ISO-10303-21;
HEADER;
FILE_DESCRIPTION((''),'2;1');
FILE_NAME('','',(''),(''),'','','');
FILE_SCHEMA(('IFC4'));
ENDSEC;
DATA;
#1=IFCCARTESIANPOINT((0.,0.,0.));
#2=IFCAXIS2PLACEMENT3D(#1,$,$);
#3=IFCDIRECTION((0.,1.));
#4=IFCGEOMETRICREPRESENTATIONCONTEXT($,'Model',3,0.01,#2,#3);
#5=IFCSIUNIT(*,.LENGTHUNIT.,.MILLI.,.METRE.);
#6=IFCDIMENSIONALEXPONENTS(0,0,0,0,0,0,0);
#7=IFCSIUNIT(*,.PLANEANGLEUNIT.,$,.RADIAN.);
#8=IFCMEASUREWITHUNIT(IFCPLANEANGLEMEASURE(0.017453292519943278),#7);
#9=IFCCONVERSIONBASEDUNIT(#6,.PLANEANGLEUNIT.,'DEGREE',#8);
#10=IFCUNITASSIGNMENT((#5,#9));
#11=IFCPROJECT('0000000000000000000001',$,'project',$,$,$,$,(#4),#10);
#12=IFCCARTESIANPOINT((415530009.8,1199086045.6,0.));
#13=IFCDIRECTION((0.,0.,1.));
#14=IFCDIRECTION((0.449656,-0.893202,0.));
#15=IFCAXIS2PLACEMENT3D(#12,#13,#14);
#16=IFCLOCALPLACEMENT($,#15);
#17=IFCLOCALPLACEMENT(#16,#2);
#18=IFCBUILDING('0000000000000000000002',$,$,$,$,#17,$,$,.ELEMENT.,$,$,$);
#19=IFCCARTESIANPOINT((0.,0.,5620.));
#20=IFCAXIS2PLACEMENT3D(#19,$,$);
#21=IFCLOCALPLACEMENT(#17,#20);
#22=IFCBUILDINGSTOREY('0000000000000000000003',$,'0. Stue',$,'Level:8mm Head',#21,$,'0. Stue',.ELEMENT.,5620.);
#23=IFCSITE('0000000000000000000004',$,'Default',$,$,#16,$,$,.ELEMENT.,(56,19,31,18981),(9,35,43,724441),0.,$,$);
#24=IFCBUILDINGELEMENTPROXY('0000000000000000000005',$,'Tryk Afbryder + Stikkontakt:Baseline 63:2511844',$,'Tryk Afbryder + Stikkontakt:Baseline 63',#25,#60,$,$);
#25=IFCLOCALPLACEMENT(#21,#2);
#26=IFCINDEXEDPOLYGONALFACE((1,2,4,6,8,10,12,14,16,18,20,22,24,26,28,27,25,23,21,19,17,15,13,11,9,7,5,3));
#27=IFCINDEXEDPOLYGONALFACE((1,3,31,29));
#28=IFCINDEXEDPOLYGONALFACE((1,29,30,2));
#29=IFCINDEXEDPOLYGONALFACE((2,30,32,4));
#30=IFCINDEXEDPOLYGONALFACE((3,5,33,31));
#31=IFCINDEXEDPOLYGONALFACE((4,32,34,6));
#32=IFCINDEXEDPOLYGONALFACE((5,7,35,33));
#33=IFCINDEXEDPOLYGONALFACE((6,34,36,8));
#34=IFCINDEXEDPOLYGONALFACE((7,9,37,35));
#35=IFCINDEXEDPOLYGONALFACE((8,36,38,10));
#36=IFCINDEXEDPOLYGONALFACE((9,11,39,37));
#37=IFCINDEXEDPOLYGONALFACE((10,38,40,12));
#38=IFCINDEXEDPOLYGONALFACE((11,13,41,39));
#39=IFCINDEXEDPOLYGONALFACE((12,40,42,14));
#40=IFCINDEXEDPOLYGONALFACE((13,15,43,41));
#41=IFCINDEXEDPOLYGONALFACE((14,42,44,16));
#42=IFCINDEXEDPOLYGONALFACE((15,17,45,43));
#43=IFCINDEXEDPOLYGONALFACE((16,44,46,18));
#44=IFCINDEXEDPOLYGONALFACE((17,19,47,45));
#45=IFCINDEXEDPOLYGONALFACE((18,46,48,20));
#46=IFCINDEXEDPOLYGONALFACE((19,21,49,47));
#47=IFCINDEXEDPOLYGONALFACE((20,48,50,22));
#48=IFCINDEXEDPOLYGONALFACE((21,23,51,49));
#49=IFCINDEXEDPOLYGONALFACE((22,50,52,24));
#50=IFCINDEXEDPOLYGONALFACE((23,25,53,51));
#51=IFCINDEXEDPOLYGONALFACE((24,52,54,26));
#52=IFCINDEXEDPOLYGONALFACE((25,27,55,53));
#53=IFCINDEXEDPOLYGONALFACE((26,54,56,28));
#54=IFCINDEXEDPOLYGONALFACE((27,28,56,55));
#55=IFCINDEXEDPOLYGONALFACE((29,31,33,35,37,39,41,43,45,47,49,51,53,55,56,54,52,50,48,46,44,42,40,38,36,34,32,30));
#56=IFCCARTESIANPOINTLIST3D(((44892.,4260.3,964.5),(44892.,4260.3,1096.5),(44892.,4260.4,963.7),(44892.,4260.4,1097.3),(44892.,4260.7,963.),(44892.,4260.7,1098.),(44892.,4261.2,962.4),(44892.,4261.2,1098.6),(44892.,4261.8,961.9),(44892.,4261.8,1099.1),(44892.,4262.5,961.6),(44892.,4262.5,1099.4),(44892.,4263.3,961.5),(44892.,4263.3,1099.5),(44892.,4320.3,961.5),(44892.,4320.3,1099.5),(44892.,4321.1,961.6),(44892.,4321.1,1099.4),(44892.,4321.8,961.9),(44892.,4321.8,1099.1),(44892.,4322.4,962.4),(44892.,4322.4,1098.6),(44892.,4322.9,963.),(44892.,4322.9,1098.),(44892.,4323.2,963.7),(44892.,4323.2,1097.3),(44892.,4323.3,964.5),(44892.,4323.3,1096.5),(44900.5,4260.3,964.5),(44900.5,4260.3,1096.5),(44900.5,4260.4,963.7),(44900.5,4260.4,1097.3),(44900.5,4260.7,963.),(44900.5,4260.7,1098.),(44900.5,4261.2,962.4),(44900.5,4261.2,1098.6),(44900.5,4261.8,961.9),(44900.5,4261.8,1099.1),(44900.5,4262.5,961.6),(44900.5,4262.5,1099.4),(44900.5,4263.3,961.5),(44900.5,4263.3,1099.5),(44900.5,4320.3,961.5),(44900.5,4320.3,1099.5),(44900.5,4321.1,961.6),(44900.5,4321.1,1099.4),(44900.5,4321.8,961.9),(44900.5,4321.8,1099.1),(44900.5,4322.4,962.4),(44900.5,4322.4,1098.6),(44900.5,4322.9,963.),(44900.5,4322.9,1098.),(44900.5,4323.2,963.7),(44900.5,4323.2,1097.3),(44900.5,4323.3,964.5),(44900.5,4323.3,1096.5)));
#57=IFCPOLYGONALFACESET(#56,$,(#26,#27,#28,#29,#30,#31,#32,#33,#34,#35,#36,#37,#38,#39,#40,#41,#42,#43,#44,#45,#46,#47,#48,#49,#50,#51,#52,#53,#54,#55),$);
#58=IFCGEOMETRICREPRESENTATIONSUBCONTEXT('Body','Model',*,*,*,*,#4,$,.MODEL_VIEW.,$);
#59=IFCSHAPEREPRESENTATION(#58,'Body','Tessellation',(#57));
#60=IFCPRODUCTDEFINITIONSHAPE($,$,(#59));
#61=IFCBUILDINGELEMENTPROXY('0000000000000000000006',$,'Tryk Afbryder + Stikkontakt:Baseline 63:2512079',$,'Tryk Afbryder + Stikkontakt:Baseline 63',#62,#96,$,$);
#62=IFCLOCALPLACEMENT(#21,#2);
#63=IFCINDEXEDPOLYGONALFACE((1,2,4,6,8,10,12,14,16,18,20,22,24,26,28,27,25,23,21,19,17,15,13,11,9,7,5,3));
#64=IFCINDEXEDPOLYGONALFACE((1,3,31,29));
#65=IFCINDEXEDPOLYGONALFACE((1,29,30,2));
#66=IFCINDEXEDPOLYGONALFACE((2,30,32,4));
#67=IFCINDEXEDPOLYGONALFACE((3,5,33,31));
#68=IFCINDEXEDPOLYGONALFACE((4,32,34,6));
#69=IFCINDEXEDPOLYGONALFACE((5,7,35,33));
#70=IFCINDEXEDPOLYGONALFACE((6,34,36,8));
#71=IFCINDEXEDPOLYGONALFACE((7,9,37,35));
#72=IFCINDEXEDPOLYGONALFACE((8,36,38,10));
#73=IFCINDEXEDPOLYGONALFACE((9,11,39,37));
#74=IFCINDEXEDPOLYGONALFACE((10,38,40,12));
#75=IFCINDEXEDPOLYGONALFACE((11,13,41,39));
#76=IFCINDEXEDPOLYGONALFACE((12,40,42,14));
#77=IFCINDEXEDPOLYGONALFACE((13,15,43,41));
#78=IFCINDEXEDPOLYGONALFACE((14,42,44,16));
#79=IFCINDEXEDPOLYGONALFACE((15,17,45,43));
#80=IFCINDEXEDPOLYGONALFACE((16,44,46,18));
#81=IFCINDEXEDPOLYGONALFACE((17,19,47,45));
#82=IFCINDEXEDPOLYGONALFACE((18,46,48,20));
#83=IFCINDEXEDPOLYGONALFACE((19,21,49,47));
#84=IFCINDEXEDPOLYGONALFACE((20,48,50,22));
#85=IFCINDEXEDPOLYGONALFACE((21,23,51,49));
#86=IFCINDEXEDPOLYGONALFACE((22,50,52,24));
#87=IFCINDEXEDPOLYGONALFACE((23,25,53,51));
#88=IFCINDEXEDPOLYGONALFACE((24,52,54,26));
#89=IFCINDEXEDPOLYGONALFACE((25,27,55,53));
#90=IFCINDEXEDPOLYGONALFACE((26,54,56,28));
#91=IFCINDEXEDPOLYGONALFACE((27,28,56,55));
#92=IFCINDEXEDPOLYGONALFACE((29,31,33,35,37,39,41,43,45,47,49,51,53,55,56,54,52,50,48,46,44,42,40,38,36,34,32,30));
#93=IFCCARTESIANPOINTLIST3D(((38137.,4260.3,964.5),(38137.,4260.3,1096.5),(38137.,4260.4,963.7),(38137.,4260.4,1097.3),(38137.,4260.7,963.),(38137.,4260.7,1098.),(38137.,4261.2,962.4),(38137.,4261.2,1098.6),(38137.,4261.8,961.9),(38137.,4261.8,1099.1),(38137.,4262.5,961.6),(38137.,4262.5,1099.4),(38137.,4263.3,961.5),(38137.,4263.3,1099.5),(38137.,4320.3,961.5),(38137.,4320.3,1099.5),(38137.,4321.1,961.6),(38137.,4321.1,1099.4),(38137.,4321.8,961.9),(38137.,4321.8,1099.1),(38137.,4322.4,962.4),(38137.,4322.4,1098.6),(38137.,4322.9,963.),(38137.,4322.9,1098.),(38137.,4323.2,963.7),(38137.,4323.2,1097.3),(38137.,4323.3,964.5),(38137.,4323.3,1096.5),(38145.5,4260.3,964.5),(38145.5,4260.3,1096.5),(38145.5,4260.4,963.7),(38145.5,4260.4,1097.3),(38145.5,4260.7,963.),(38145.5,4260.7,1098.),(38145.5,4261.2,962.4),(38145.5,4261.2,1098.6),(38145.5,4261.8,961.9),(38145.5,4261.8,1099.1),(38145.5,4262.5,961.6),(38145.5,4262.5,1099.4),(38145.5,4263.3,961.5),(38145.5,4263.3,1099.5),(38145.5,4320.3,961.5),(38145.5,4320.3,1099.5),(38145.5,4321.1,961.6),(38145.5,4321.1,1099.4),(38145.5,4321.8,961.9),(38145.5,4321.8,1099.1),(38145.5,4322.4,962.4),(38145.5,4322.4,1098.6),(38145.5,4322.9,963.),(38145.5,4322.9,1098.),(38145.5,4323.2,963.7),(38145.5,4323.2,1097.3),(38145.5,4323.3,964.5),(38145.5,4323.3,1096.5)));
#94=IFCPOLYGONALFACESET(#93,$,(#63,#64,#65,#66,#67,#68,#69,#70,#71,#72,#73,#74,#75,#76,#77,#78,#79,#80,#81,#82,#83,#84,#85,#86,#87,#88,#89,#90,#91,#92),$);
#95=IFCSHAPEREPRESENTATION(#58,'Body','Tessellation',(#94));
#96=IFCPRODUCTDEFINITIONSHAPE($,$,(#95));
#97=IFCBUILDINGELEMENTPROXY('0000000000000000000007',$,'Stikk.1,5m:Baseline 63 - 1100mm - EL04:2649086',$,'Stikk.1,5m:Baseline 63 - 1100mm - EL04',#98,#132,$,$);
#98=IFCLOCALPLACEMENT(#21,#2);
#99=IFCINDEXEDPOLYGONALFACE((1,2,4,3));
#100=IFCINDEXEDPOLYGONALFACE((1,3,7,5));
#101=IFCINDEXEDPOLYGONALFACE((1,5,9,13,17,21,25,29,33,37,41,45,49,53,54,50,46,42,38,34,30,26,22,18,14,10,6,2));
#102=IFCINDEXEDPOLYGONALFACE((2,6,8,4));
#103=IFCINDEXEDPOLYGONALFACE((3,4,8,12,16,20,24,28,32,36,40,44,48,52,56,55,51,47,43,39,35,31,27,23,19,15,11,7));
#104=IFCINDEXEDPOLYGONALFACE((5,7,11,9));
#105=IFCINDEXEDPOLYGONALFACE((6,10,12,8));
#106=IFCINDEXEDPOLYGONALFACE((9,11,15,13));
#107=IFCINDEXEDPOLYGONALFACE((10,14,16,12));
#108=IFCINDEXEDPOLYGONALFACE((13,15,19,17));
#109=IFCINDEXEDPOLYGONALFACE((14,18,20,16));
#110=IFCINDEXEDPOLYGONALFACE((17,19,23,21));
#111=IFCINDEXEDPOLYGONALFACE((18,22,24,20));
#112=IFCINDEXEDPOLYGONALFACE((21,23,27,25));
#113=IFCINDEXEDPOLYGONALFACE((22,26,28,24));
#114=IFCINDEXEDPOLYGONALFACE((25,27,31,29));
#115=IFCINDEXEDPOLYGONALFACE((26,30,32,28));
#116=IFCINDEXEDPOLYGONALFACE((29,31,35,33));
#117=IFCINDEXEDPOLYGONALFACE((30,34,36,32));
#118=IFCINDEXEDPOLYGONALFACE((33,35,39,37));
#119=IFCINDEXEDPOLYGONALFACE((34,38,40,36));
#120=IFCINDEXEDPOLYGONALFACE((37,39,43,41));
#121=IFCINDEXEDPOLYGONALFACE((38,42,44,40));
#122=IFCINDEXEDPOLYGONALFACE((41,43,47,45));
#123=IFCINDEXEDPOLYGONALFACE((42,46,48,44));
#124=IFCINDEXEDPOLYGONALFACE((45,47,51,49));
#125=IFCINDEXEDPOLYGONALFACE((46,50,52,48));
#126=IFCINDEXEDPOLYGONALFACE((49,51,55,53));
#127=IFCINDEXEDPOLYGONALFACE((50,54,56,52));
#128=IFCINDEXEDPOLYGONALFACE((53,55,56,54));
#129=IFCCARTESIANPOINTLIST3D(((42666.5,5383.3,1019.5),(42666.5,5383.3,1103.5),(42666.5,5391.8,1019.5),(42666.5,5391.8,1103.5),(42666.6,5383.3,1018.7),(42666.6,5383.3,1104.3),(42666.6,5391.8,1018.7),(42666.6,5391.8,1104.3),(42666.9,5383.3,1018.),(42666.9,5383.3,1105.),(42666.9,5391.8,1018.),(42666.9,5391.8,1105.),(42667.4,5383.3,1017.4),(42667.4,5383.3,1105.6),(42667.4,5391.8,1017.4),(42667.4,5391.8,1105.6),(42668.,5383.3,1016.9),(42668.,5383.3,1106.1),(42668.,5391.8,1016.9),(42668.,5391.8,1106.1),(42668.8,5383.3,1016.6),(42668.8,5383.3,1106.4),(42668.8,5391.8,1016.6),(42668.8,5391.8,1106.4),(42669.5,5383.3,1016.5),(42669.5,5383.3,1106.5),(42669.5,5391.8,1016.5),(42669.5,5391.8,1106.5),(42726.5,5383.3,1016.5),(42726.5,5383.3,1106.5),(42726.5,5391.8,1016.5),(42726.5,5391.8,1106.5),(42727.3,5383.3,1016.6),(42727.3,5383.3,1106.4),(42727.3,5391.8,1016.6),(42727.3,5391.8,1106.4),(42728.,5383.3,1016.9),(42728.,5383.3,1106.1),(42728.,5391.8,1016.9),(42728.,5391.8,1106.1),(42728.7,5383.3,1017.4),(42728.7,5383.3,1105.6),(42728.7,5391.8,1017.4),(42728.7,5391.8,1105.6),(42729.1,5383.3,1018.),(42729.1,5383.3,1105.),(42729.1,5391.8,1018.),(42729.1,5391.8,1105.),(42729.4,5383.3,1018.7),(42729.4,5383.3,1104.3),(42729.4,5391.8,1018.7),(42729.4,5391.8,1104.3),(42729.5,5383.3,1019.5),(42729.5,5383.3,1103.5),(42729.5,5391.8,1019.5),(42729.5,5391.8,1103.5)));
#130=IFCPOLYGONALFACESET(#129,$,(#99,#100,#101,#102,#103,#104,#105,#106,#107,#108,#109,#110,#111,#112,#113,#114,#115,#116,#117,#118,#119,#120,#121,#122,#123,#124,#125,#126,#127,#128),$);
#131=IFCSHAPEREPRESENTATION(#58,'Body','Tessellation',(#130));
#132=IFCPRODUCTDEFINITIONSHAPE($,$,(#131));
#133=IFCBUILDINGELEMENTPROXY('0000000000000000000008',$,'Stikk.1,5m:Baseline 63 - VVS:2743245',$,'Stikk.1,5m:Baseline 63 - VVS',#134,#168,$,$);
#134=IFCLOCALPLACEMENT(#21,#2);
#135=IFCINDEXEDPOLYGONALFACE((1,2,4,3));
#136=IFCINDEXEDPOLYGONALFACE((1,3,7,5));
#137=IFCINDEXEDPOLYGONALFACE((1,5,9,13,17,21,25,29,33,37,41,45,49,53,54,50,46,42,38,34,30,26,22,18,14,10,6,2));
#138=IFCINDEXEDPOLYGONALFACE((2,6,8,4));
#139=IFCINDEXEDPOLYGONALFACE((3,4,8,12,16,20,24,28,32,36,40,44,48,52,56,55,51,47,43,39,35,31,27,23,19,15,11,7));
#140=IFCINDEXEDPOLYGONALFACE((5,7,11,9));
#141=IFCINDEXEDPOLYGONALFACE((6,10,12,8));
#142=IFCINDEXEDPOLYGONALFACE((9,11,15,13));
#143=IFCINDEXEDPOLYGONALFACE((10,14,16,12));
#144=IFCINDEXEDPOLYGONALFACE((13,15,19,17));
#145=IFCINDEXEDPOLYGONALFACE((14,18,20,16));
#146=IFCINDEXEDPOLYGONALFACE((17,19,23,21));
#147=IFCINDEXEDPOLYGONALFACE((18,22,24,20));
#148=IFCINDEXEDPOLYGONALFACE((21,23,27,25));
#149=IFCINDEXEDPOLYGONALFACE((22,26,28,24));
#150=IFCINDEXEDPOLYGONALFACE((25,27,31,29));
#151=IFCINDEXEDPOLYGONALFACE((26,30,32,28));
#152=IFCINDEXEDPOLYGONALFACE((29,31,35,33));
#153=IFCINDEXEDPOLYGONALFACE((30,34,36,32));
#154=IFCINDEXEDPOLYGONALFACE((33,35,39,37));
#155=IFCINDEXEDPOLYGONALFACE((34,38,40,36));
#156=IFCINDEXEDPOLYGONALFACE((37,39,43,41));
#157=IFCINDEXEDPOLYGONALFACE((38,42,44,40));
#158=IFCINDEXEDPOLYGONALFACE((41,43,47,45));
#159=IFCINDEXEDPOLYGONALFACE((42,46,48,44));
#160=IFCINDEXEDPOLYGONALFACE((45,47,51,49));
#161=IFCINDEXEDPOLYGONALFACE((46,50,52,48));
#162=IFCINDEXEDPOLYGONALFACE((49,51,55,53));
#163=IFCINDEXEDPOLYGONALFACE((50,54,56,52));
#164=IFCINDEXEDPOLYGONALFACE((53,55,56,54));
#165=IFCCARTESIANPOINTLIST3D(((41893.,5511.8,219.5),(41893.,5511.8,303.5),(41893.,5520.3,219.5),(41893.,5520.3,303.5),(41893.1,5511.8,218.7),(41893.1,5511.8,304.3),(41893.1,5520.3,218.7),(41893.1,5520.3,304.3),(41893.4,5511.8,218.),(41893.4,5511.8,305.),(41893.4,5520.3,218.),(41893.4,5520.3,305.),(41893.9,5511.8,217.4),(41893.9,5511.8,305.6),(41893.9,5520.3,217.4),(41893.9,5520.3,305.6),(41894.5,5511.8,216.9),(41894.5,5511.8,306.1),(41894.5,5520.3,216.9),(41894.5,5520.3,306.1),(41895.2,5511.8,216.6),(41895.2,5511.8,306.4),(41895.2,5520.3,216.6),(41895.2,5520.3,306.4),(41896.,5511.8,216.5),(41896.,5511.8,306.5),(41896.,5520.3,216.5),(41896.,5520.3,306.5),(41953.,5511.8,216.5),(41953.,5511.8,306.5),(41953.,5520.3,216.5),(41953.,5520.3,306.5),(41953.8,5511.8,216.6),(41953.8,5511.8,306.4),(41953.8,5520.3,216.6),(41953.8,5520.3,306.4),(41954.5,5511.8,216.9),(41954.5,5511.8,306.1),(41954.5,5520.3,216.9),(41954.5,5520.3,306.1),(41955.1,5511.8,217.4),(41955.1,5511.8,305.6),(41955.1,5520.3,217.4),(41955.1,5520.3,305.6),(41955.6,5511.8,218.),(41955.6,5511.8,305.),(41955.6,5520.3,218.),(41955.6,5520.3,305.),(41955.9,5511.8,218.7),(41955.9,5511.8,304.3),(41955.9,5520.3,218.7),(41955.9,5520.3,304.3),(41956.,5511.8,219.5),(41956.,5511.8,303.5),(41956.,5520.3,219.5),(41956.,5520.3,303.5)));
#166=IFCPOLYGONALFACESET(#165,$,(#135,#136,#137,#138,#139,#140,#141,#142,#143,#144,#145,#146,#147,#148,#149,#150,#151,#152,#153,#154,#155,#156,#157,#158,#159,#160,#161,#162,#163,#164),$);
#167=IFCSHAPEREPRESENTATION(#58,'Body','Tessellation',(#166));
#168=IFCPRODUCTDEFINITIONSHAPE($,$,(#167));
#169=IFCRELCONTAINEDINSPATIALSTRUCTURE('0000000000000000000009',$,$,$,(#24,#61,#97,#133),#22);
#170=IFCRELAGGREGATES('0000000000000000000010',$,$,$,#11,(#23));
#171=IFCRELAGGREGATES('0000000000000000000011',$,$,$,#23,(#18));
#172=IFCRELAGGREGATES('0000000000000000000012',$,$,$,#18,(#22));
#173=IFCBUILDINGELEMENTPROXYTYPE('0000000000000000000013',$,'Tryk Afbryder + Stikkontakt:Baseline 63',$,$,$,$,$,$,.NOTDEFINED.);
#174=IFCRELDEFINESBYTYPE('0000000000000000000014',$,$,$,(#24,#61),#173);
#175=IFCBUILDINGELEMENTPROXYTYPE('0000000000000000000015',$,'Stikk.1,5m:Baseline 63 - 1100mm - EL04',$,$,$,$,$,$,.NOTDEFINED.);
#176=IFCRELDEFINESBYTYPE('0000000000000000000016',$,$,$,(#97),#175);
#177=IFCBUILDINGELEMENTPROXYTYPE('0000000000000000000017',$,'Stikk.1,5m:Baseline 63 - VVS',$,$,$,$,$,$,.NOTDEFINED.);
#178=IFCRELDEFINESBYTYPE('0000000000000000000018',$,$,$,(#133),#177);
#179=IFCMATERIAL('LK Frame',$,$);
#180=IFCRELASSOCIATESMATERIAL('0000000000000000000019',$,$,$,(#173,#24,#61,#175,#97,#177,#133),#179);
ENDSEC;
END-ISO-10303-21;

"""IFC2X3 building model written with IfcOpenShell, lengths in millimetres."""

from ifc_helpers import new_model, entity, si_unit, converted_unit, direction, frame, frame_2d, origin, place, context, subcontext, project, spatial, polyline, circle_curve, parameter, trimmed, segment, composite_curve, outline, extrude, source, transform, mapped, material, type_object, type_shapes, element, save


model = new_model("IFC2X3")

# Units and contexts
model_context = context("Model", 3, precision=0.01, world=origin(), true_north=direction((0.0, 1.0)))
body_context = subcontext(model_context, "Body", "Model", "MODEL_VIEW")
ifc_project = project(units=[si_unit("LENGTHUNIT", "METRE", prefix="MILLI"), converted_unit("PLANEANGLEUNIT", "DEGREE", entity("IfcPlaneAngleMeasure", 0.017453292519943278), si_unit("PLANEANGLEUNIT", "RADIAN"), dimensions=[0, 0, 0, 0, 0, 0, 0])], contexts=[model_context])

# Site, building, storey
site_placement = place(None, frame((415530009.8, 1199086045.6, 0.0), z_axis=(0.0, 0.0, 1.0), x_axis=(0.449656, -0.893202, 0.0)))
site = spatial("IfcSite", under=ifc_project, at=site_placement, Name="Default", CompositionType="ELEMENT", RefLatitude=(56, 19, 31, 18981), RefLongitude=(9, 35, 43, 724441), RefElevation=0.0)
building_placement = place(site_placement, origin())
building = spatial("IfcBuilding", under=site, at=building_placement, CompositionType="ELEMENT")
storey_placement = place(building_placement, frame((0.0, 0.0, 5620.0)))
storey = spatial("IfcBuildingStorey", under=building, at=storey_placement, Name="0. Stue", ObjectType="Level:8mm Head", LongName="0. Stue", CompositionType="ELEMENT", Elevation=5620.0)

# Building element proxies
ifc_material_1 = material(Name="LK Frame")
building_element_proxy_type_1 = type_object("IfcBuildingElementProxyType", Name="Tryk Afbryder + Stikkontakt:Baseline 63", PredefinedType="NOTDEFINED", material=ifc_material_1)
shared_shape_1 = source(origin(), body_context, "Body", "SweptSolid", [
    extrude(outline(composite_curve([segment(trimmed(circle_curve(frame_2d((-66.0, 28.5), x_axis=(1.0, 0.0)), 3.0), [parameter(90.0)], [parameter(180.0)], True, "PARAMETER"), True, "CONTINUOUS"), segment(polyline([(-69.0, 28.5), (-69.0, -28.5)]), True, "CONTINUOUS"), segment(trimmed(circle_curve(frame_2d((-66.0, -28.5), x_axis=(1.0, 0.0)), 3.0), [parameter(180.0)], [parameter(270.0)], True, "PARAMETER"), True, "CONTINUOUS"), segment(polyline([(-66.0, -31.5), (66.0, -31.5)]), True, "CONTINUOUS"), segment(trimmed(circle_curve(frame_2d((66.0, -28.5), x_axis=(-1.0, 0.0)), 3.0), [parameter(90.0)], [parameter(180.0)], True, "PARAMETER"), True, "CONTINUOUS"), segment(polyline([(69.0, -28.5), (69.0, 28.5)]), True, "CONTINUOUS"), segment(trimmed(circle_curve(frame_2d((66.0, 28.5), x_axis=(-1.0, 0.0)), 3.0), [parameter(180.0)], [parameter(270.0)], True, "PARAMETER"), True, "CONTINUOUS"), segment(polyline([(66.0, 31.5), (-66.0, 31.5)]), True, "CONTINUOUS")], self_intersect=False)), frame((0.0, 69.5, 0.0), z_axis=(0.0, 0.0, 1.0), x_axis=(0.0, -1.0, 0.0)), (0.0, 0.0, 1.0), 8.5),
])
type_shapes(building_element_proxy_type_1, [shared_shape_1])
for number, where, z_axis, x_axis, name in (
    (1, (44900.5, 4291.8, 1100.0), (-1.0, 0.0, 0.0), (0.0, 1.0, 0.0), "Tryk Afbryder + Stikkontakt:Baseline 63:2511844"),
    (2, (38145.5, 4291.8, 1100.0), (-1.0, 0.0, 0.0), (0.0, 1.0, 0.0), "Tryk Afbryder + Stikkontakt:Baseline 63:2512079"),
):
    element("IfcBuildingElementProxy", number, at=place(storey_placement, frame(where, z_axis=z_axis, x_axis=x_axis)), inside=storey, type_object=building_element_proxy_type_1, material=ifc_material_1, Name=name, ObjectType="Tryk Afbryder + Stikkontakt:Baseline 63", context=body_context, shape_type="MappedRepresentation", body=[
        mapped(shared_shape_1, transform((0.0, 0.0, 0.0), scale=1.0)),
    ])
building_element_proxy_type_2 = type_object("IfcBuildingElementProxyType", Name="Stikk.1,5m:Baseline 63 - 1100mm - EL04", PredefinedType="NOTDEFINED", material=ifc_material_1)
shared_shape_2 = source(origin(), body_context, "Body", "SweptSolid", [
    extrude(outline(composite_curve([segment(trimmed(circle_curve(frame_2d((-42.0, 28.5), x_axis=(1.0, 0.0)), 3.0), [parameter(90.0)], [parameter(180.0)], True, "PARAMETER"), True, "CONTINUOUS"), segment(polyline([(-45.0, 28.5), (-45.0, -28.5)]), True, "CONTINUOUS"), segment(trimmed(circle_curve(frame_2d((-42.0, -28.5), x_axis=(1.0, 0.0)), 3.0), [parameter(180.0)], [parameter(270.0)], True, "PARAMETER"), True, "CONTINUOUS"), segment(polyline([(-42.0, -31.5), (42.0, -31.5)]), True, "CONTINUOUS"), segment(trimmed(circle_curve(frame_2d((42.0, -28.5), x_axis=(-1.0, 0.0)), 3.0), [parameter(90.0)], [parameter(180.0)], True, "PARAMETER"), True, "CONTINUOUS"), segment(polyline([(45.0, -28.5), (45.0, 28.5)]), True, "CONTINUOUS"), segment(trimmed(circle_curve(frame_2d((42.0, 28.5), x_axis=(-1.0, 0.0)), 3.0), [parameter(180.0)], [parameter(270.0)], True, "PARAMETER"), True, "CONTINUOUS"), segment(polyline([(42.0, 31.5), (-42.0, 31.5)]), True, "CONTINUOUS")], self_intersect=False)), frame((0.0, 38.5, 0.0), z_axis=(0.0, 0.0, 1.0), x_axis=(0.0, -1.0, 0.0)), (0.0, 0.0, 1.0), 8.5),
])
type_shapes(building_element_proxy_type_2, [shared_shape_2])
proxy_1_placement = place(storey_placement, frame((42698.0, 5391.8, 1100.0), z_axis=(0.0, -1.0, 0.0), x_axis=(-1.0, 0.0, 0.0)))
element("IfcBuildingElementProxy", 3, at=proxy_1_placement, inside=storey, type_object=building_element_proxy_type_2, material=ifc_material_1, Name="Stikk.1,5m:Baseline 63 - 1100mm - EL04:2649086", ObjectType="Stikk.1,5m:Baseline 63 - 1100mm - EL04", context=body_context, shape_type="MappedRepresentation", body=[
    mapped(shared_shape_2, transform((0.0, 0.0, 0.0), scale=1.0)),
])
building_element_proxy_type_3 = type_object("IfcBuildingElementProxyType", Name="Stikk.1,5m:Baseline 63 - VVS", PredefinedType="NOTDEFINED", material=ifc_material_1)
shared_shape_3 = source(origin(), body_context, "Body", "SweptSolid", [
    extrude(outline(composite_curve([segment(polyline([(-42.0, -31.5), (42.0, -31.5)]), True, "CONTINUOUS"), segment(trimmed(circle_curve(frame_2d((42.0, -28.5), x_axis=(-1.0, 0.0)), 3.0), [parameter(90.0)], [parameter(180.0)], True, "PARAMETER"), True, "CONTINUOUS"), segment(polyline([(45.0, -28.5), (45.0, 28.5)]), True, "CONTINUOUS"), segment(trimmed(circle_curve(frame_2d((42.0, 28.5), x_axis=(-1.0, 0.0)), 3.0), [parameter(180.0)], [parameter(270.0)], True, "PARAMETER"), True, "CONTINUOUS"), segment(polyline([(42.0, 31.5), (-42.0, 31.5)]), True, "CONTINUOUS"), segment(trimmed(circle_curve(frame_2d((-42.0, 28.5), x_axis=(1.0, 0.0)), 3.0), [parameter(90.0)], [parameter(180.0)], True, "PARAMETER"), True, "CONTINUOUS"), segment(polyline([(-45.0, 28.5), (-45.0, -28.5)]), True, "CONTINUOUS"), segment(trimmed(circle_curve(frame_2d((-42.0, -28.5), x_axis=(1.0, 0.0)), 3.0), [parameter(180.0)], [parameter(270.0)], True, "PARAMETER"), True, "CONTINUOUS")], self_intersect=False)), frame((0.0, -38.5, 0.0), z_axis=(0.0, 0.0, 1.0), x_axis=(0.0, 1.0, 0.0)), (0.0, 0.0, 1.0), 8.5),
])
type_shapes(building_element_proxy_type_3, [shared_shape_3])
proxy_2_placement = place(storey_placement, frame((41924.5, 5511.8, 300.0), z_axis=(0.0, 1.0, 0.0), x_axis=(-1.0, 0.0, 0.0)))
element("IfcBuildingElementProxy", 4, at=proxy_2_placement, inside=storey, type_object=building_element_proxy_type_3, material=ifc_material_1, Name="Stikk.1,5m:Baseline 63 - VVS:2743245", ObjectType="Stikk.1,5m:Baseline 63 - VVS", context=body_context, shape_type="MappedRepresentation", body=[
    mapped(shared_shape_3, transform((0.0, 0.0, 0.0), scale=1.0)),
])

save(model, "model.ifc")
